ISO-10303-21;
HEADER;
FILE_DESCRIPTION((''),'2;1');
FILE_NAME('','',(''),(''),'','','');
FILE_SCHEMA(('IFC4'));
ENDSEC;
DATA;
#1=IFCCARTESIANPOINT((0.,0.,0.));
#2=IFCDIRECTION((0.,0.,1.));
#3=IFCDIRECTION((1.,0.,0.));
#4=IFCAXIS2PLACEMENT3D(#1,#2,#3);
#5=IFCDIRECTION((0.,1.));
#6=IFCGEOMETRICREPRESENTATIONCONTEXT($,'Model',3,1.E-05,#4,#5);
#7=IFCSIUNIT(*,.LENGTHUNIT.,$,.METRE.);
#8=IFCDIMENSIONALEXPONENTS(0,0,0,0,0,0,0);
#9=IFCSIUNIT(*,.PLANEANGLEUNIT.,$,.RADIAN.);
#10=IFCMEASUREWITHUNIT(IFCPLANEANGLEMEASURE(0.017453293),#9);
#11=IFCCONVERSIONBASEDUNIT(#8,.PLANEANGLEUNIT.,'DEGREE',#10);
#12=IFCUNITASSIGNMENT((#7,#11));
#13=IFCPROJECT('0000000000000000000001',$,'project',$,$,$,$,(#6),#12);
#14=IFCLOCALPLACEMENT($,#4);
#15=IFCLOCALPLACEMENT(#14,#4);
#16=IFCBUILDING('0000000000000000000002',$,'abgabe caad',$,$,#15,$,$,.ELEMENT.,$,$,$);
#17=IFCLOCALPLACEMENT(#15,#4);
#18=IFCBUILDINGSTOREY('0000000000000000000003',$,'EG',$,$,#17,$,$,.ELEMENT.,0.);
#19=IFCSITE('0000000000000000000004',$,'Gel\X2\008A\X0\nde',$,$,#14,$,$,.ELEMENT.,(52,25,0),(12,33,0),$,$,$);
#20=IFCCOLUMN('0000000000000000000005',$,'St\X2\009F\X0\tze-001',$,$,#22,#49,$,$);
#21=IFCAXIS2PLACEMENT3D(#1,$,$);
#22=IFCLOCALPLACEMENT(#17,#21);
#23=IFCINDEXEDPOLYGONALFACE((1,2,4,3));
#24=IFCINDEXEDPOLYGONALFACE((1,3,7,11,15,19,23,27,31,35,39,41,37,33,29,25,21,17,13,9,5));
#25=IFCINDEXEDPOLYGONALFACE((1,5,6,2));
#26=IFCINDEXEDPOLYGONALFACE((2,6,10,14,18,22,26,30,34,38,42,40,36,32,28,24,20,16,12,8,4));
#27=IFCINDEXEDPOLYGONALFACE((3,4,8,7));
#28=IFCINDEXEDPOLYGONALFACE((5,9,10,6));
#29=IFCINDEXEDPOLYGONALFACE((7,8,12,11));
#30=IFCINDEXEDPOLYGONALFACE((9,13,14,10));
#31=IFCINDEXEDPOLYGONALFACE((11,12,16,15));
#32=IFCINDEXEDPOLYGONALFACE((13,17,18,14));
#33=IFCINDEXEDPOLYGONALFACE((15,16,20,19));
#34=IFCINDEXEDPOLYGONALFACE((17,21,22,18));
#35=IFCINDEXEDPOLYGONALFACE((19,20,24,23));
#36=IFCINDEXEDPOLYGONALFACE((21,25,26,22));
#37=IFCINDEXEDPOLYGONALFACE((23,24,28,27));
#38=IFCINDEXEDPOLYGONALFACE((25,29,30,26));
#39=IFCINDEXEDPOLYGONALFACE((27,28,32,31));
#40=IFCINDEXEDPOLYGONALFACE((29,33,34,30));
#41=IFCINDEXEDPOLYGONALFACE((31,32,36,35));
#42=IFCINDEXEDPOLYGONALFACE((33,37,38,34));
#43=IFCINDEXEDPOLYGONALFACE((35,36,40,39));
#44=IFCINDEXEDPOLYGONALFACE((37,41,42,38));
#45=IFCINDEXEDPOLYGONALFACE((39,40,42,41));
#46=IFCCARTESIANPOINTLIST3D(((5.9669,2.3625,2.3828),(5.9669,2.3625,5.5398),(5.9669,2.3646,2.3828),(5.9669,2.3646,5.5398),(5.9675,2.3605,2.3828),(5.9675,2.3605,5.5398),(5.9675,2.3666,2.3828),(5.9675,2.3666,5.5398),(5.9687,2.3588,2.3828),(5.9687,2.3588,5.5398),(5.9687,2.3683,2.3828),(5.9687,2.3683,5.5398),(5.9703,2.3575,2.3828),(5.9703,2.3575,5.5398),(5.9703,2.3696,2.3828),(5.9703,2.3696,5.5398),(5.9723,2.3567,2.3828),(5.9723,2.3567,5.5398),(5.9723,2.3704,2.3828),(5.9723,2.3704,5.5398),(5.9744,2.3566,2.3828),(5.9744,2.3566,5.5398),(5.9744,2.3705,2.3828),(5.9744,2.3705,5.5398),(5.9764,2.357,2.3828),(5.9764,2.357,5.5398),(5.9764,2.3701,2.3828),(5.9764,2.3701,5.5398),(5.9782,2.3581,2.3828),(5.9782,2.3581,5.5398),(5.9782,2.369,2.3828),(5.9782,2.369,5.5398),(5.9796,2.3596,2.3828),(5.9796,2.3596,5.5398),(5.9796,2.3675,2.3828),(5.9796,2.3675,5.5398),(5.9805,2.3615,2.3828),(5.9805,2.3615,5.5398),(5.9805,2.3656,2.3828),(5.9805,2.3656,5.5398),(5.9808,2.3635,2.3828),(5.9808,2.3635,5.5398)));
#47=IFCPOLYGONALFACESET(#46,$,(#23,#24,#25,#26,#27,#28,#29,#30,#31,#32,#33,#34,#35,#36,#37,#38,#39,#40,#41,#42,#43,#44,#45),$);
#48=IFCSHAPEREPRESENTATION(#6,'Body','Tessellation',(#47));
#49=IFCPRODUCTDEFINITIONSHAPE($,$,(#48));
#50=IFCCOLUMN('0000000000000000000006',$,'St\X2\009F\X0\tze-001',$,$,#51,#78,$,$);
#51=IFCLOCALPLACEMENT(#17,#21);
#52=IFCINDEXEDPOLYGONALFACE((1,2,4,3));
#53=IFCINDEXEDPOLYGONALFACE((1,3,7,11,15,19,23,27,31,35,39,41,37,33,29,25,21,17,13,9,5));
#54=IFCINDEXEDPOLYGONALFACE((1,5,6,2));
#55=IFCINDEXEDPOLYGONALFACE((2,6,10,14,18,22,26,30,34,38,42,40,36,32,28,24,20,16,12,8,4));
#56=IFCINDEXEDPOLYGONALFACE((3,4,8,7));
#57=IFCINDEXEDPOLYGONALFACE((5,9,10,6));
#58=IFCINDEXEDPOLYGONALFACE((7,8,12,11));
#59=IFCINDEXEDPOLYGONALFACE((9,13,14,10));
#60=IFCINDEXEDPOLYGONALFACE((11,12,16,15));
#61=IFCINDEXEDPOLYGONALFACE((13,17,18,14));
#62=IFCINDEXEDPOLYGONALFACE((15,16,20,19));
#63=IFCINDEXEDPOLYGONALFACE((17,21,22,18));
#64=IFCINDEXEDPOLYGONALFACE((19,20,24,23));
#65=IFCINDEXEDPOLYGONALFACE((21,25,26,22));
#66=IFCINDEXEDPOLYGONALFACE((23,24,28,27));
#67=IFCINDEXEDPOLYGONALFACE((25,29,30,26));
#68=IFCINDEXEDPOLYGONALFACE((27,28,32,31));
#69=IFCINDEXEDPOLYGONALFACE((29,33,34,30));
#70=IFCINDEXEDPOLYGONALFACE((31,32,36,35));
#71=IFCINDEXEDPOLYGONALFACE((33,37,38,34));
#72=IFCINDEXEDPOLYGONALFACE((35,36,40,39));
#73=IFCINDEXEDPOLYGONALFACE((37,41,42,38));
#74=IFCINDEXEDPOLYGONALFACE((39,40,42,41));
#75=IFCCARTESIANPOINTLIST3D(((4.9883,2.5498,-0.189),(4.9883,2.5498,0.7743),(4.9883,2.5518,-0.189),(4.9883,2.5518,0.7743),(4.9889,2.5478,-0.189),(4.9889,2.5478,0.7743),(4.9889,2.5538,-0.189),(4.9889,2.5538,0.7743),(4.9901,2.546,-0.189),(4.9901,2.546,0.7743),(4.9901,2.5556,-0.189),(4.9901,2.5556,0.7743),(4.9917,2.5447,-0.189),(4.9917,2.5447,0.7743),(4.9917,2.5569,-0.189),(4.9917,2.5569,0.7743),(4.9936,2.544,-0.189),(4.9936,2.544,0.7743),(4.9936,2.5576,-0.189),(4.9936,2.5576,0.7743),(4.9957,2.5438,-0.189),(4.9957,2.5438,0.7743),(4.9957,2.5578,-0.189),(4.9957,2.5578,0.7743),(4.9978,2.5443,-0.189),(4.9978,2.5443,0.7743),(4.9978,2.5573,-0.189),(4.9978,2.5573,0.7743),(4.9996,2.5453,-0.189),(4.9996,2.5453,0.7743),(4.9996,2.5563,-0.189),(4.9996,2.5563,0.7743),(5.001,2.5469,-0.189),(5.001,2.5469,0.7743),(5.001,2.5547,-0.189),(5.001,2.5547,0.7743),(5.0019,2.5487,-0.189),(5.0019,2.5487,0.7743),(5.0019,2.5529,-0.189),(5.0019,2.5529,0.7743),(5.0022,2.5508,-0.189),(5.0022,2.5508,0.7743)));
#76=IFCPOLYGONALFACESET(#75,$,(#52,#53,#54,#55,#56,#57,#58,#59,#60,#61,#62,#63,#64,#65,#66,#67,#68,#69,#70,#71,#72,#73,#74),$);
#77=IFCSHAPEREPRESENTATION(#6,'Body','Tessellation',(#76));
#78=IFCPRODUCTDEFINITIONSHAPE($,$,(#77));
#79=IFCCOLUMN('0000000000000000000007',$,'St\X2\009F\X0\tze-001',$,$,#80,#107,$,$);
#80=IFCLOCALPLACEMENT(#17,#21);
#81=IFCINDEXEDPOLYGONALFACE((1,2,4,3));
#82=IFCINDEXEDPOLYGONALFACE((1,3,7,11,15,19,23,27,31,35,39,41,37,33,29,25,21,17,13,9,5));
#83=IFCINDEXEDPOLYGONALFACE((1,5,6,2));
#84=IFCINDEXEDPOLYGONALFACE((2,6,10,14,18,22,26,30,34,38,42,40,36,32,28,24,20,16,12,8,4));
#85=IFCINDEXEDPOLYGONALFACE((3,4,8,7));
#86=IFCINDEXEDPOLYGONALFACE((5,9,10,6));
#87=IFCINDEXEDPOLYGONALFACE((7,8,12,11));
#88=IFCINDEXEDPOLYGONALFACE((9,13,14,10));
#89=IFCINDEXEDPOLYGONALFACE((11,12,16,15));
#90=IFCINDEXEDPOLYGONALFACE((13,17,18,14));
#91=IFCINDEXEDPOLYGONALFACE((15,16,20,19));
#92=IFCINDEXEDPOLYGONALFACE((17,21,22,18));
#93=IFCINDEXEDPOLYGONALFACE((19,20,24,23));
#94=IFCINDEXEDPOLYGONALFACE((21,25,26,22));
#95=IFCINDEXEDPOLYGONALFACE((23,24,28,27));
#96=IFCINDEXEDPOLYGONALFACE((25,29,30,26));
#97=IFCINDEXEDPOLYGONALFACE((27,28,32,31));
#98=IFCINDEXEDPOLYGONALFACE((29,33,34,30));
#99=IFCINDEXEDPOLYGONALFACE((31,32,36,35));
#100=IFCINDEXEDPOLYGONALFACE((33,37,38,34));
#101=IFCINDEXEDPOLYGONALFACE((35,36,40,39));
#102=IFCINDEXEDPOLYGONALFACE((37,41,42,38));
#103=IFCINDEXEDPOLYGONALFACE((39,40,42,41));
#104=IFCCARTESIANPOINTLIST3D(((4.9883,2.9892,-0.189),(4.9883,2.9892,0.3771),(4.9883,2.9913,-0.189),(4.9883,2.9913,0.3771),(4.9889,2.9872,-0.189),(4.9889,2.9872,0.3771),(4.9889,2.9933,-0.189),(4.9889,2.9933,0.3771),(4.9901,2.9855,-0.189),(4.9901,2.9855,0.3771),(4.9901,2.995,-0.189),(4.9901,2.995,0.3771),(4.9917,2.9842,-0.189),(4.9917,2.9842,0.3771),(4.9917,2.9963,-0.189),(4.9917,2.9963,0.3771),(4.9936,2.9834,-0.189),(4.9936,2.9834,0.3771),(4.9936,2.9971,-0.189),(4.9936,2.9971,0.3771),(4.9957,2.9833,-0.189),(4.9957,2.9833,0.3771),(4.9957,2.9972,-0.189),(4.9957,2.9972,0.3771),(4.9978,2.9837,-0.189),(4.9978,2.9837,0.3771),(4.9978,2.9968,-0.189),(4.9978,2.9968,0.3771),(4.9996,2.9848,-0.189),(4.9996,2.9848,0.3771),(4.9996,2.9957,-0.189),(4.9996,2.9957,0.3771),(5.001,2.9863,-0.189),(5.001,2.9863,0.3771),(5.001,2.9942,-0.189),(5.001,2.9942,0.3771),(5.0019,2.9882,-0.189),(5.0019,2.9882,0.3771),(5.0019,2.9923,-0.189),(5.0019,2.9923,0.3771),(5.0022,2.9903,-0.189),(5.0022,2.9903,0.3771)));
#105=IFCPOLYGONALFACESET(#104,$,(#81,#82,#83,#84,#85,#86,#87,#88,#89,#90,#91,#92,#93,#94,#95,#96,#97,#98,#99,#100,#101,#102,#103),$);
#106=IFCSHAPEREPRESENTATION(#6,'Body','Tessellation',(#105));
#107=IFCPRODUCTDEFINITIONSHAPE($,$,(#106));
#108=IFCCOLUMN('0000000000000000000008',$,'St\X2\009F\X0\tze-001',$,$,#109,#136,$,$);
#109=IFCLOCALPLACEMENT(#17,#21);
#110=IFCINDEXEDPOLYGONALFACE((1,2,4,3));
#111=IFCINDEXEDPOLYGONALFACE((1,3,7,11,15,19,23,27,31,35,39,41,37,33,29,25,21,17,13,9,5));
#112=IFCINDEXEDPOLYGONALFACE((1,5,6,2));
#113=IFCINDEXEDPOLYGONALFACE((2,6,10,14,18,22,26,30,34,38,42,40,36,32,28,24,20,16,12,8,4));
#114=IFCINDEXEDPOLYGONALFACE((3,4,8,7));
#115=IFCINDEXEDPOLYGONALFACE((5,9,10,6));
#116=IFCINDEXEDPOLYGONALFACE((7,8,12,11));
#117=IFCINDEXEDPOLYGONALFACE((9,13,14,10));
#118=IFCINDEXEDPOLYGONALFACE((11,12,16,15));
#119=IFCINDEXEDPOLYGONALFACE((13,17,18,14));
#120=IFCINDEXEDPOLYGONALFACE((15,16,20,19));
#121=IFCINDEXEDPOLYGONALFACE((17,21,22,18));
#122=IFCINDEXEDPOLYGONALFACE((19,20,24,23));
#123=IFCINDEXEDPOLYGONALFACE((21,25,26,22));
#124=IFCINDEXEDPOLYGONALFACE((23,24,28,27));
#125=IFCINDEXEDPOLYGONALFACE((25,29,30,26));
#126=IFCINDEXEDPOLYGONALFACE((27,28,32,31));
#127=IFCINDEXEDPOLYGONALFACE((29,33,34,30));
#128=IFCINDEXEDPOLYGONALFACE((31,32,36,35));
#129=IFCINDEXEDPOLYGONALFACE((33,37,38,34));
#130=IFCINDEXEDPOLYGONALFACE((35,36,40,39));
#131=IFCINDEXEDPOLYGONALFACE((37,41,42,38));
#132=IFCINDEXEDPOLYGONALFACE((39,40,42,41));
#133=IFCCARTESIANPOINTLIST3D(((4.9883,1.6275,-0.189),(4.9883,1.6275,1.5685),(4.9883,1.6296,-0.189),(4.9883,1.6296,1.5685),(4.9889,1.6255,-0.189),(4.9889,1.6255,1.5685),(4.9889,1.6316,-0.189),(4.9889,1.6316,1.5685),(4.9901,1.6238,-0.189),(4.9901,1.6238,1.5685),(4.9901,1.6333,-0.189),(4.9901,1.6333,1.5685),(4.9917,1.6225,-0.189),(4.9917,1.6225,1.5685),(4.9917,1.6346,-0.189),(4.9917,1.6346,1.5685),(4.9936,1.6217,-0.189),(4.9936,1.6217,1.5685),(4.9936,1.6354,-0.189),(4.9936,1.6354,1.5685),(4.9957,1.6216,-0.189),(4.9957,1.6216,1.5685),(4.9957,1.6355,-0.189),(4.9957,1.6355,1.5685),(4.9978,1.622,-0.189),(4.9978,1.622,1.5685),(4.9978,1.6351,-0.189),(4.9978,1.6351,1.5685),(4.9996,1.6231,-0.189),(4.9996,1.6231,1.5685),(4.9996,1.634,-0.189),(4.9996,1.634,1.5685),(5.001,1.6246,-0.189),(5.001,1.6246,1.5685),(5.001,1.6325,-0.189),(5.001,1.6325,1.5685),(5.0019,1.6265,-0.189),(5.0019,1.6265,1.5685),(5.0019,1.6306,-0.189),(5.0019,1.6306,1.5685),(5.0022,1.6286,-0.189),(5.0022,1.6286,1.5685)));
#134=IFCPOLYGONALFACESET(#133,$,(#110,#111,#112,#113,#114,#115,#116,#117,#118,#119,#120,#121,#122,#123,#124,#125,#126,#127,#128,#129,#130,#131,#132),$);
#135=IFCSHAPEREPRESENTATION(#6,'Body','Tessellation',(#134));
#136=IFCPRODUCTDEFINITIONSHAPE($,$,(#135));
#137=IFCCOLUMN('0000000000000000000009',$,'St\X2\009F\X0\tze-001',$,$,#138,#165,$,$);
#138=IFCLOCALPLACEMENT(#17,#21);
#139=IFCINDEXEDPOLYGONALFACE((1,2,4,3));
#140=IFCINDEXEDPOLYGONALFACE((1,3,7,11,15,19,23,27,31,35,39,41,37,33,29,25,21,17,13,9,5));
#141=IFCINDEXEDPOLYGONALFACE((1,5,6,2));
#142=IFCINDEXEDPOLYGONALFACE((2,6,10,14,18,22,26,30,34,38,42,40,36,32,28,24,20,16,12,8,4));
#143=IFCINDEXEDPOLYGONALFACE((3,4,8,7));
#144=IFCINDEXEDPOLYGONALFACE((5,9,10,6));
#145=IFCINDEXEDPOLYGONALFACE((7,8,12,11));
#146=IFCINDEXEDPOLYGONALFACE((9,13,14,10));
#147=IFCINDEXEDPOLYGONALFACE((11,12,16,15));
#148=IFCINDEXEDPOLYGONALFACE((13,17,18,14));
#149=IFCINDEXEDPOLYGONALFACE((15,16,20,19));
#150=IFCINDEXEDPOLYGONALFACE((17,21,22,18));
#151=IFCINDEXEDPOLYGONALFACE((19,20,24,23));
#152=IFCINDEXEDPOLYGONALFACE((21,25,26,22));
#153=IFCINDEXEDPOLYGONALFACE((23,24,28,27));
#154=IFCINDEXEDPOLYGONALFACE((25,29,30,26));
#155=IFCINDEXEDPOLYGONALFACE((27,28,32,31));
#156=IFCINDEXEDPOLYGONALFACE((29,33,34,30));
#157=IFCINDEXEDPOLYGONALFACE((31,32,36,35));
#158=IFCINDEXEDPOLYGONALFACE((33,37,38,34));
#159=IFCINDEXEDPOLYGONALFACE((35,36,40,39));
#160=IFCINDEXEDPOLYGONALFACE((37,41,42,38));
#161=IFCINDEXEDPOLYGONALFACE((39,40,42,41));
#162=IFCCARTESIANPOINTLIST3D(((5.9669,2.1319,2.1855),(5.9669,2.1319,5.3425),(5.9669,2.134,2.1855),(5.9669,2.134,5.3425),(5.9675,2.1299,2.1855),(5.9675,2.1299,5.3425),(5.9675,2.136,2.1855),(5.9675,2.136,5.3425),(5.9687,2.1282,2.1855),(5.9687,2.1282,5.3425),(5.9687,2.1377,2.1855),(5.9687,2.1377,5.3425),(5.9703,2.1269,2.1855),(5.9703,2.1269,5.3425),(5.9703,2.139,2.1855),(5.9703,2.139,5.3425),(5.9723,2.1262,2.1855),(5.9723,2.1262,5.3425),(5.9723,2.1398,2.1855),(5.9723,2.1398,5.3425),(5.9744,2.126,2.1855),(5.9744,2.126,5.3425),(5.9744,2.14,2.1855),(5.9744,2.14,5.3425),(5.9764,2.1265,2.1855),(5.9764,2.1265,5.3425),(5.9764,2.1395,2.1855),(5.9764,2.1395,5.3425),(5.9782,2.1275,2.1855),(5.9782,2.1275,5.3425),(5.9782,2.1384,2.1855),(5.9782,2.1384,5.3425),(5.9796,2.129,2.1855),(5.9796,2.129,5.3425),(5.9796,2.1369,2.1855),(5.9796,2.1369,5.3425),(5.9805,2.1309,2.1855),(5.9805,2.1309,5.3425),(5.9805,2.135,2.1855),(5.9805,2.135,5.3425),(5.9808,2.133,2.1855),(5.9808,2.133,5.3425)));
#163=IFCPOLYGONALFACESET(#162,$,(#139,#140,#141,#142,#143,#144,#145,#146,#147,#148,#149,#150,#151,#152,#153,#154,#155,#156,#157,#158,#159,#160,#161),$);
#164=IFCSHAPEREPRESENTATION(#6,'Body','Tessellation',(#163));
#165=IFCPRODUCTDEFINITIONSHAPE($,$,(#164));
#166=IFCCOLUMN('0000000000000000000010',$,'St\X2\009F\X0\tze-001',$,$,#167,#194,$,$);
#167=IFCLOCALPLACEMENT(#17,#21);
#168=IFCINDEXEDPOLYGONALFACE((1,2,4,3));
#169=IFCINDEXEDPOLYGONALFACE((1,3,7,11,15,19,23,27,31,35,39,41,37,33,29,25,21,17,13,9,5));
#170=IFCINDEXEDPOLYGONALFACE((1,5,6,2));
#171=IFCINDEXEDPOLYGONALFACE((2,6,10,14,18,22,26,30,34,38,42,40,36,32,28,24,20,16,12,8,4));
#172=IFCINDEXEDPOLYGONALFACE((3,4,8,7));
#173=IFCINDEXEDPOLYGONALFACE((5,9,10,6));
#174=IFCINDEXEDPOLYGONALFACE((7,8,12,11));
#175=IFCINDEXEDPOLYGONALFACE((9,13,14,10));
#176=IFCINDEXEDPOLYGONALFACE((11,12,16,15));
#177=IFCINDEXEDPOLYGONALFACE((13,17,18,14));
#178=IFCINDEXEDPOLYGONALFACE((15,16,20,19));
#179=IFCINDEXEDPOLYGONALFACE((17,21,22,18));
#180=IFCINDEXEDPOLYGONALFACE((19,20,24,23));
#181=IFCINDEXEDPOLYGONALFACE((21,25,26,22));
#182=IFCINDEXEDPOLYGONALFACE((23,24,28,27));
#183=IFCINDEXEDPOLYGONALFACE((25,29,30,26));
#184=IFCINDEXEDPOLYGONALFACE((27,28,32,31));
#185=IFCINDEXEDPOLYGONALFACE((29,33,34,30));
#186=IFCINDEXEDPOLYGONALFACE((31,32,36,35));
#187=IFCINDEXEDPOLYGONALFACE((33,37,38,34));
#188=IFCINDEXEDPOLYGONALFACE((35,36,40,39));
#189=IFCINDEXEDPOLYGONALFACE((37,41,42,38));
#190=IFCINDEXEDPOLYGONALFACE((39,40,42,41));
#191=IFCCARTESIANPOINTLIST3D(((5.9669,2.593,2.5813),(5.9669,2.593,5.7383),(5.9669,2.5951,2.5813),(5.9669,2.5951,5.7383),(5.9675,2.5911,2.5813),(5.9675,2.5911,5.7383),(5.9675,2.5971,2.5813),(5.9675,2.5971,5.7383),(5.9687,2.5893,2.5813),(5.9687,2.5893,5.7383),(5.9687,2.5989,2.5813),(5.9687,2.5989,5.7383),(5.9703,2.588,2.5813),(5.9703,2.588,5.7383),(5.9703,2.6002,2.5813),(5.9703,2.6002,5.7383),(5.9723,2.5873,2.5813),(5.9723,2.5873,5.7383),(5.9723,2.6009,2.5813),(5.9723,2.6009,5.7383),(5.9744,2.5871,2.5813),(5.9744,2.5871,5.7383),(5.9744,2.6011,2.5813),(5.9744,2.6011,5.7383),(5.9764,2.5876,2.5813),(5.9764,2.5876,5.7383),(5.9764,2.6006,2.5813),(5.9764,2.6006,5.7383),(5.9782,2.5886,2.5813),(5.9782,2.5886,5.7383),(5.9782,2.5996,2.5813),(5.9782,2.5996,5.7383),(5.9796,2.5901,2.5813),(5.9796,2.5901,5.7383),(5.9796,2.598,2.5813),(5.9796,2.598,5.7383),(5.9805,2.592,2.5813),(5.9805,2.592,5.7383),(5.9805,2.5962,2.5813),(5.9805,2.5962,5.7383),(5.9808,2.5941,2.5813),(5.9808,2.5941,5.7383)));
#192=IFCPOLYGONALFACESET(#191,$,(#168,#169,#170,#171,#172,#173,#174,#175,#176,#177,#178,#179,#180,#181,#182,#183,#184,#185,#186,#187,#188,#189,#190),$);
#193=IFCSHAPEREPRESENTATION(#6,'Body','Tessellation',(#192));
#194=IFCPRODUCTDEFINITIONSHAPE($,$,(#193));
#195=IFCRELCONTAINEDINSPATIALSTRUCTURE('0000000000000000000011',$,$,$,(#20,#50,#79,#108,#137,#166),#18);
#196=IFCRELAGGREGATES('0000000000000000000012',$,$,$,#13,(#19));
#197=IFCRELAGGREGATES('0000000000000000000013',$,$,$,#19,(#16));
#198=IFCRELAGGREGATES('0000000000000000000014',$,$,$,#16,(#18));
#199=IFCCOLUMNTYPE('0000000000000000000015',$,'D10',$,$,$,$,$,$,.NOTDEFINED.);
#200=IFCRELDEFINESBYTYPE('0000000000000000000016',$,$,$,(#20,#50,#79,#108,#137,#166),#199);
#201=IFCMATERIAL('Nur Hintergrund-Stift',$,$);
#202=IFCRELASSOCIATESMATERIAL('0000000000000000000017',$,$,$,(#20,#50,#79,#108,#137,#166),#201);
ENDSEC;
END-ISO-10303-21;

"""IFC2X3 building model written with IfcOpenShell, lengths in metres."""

from ifc_helpers import new_model, entity, si_unit, converted_unit, direction, frame, origin_with_axes, origin_2d_with_axis, place, context, project, spatial, circle, extrude, material, type_object, element, save


model = new_model("IFC2X3")

# Units and contexts
model_context = context("Model", 3, precision=1e-05, world=origin_with_axes(), true_north=direction((0.0, 1.0)))
ifc_project = project(units=[si_unit("LENGTHUNIT", "METRE"), converted_unit("PLANEANGLEUNIT", "DEGREE", entity("IfcPlaneAngleMeasure", 0.017453293), si_unit("PLANEANGLEUNIT", "RADIAN"), dimensions=[0, 0, 0, 0, 0, 0, 0])], contexts=[model_context])

# Site, building, storey
site_placement = place(None, origin_with_axes())
site = spatial("IfcSite", under=ifc_project, at=site_placement, Name="Gel\u008ande", CompositionType="ELEMENT", RefLatitude=(52, 25, 0), RefLongitude=(12, 33, 0))
building_placement = place(site_placement, origin_with_axes())
building = spatial("IfcBuilding", under=site, at=building_placement, Name="abgabe caad", CompositionType="ELEMENT")
storey_placement = place(building_placement, origin_with_axes())
storey = spatial("IfcBuildingStorey", under=building, at=storey_placement, Name="EG", CompositionType="ELEMENT", Elevation=0.0)

# Columns
ifc_material_1 = material(Name="Nur Hintergrund-Stift")
column_type = type_object("IfcColumnType", Name="D10", PredefinedType="NOTDEFINED")
column_1_placement = place(storey_placement, frame((5.9738, 2.3635, 2.3828), z_axis=(0.0, 0.0, 1.0), x_axis=(1.0, 0.0, 0.0)))
element("IfcColumn", 1, at=column_1_placement, inside=storey, type_object=column_type, material=ifc_material_1, Name="St\u009ftze-001", context=model_context, shape_type="SweptSolid", body=[
    extrude(circle(Radius=0.007, at=origin_2d_with_axis()), origin_with_axes(), (0.0, 0.0, 1.0), 3.157),
])
column_2_placement = place(storey_placement, frame((4.9952, 2.5508, -0.189), z_axis=(0.0, 0.0, 1.0), x_axis=(1.0, 0.0, 0.0)))
element("IfcColumn", 2, at=column_2_placement, inside=storey, type_object=column_type, material=ifc_material_1, Name="St\u009ftze-001", context=model_context, shape_type="SweptSolid", body=[
    extrude(circle(Radius=0.007, at=origin_2d_with_axis()), origin_with_axes(), (0.0, 0.0, 1.0), 0.9633),
])
column_3_placement = place(storey_placement, frame((4.9952, 2.9903, -0.189), z_axis=(0.0, 0.0, 1.0), x_axis=(1.0, 0.0, 0.0)))
element("IfcColumn", 3, at=column_3_placement, inside=storey, type_object=column_type, material=ifc_material_1, Name="St\u009ftze-001", context=model_context, shape_type="SweptSolid", body=[
    extrude(circle(Radius=0.007, at=origin_2d_with_axis()), origin_with_axes(), (0.0, 0.0, 1.0), 0.5661),
])
column_4_placement = place(storey_placement, frame((4.9952, 1.6286, -0.189), z_axis=(0.0, 0.0, 1.0), x_axis=(1.0, 0.0, 0.0)))
element("IfcColumn", 4, at=column_4_placement, inside=storey, type_object=column_type, material=ifc_material_1, Name="St\u009ftze-001", context=model_context, shape_type="SweptSolid", body=[
    extrude(circle(Radius=0.007, at=origin_2d_with_axis()), origin_with_axes(), (0.0, 0.0, 1.0), 1.7575),
])
for number, where, z_axis, x_axis, name in (
    (5, (5.9738, 2.133, 2.1855), (0.0, 0.0, 1.0), (1.0, 0.0, 0.0), "St\u009ftze-001"),
    (6, (5.9738, 2.5941, 2.5813), (0.0, 0.0, 1.0), (1.0, 0.0, 0.0), "St\u009ftze-001"),
):
    element("IfcColumn", number, at=place(storey_placement, frame(where, z_axis=z_axis, x_axis=x_axis)), inside=storey, type_object=column_type, material=ifc_material_1, Name=name, context=model_context, shape_type="SweptSolid", body=[
        extrude(circle(Radius=0.007, at=origin_2d_with_axis()), origin_with_axes(), (0.0, 0.0, 1.0), 3.157),
    ])

save(model, "model.ifc")
